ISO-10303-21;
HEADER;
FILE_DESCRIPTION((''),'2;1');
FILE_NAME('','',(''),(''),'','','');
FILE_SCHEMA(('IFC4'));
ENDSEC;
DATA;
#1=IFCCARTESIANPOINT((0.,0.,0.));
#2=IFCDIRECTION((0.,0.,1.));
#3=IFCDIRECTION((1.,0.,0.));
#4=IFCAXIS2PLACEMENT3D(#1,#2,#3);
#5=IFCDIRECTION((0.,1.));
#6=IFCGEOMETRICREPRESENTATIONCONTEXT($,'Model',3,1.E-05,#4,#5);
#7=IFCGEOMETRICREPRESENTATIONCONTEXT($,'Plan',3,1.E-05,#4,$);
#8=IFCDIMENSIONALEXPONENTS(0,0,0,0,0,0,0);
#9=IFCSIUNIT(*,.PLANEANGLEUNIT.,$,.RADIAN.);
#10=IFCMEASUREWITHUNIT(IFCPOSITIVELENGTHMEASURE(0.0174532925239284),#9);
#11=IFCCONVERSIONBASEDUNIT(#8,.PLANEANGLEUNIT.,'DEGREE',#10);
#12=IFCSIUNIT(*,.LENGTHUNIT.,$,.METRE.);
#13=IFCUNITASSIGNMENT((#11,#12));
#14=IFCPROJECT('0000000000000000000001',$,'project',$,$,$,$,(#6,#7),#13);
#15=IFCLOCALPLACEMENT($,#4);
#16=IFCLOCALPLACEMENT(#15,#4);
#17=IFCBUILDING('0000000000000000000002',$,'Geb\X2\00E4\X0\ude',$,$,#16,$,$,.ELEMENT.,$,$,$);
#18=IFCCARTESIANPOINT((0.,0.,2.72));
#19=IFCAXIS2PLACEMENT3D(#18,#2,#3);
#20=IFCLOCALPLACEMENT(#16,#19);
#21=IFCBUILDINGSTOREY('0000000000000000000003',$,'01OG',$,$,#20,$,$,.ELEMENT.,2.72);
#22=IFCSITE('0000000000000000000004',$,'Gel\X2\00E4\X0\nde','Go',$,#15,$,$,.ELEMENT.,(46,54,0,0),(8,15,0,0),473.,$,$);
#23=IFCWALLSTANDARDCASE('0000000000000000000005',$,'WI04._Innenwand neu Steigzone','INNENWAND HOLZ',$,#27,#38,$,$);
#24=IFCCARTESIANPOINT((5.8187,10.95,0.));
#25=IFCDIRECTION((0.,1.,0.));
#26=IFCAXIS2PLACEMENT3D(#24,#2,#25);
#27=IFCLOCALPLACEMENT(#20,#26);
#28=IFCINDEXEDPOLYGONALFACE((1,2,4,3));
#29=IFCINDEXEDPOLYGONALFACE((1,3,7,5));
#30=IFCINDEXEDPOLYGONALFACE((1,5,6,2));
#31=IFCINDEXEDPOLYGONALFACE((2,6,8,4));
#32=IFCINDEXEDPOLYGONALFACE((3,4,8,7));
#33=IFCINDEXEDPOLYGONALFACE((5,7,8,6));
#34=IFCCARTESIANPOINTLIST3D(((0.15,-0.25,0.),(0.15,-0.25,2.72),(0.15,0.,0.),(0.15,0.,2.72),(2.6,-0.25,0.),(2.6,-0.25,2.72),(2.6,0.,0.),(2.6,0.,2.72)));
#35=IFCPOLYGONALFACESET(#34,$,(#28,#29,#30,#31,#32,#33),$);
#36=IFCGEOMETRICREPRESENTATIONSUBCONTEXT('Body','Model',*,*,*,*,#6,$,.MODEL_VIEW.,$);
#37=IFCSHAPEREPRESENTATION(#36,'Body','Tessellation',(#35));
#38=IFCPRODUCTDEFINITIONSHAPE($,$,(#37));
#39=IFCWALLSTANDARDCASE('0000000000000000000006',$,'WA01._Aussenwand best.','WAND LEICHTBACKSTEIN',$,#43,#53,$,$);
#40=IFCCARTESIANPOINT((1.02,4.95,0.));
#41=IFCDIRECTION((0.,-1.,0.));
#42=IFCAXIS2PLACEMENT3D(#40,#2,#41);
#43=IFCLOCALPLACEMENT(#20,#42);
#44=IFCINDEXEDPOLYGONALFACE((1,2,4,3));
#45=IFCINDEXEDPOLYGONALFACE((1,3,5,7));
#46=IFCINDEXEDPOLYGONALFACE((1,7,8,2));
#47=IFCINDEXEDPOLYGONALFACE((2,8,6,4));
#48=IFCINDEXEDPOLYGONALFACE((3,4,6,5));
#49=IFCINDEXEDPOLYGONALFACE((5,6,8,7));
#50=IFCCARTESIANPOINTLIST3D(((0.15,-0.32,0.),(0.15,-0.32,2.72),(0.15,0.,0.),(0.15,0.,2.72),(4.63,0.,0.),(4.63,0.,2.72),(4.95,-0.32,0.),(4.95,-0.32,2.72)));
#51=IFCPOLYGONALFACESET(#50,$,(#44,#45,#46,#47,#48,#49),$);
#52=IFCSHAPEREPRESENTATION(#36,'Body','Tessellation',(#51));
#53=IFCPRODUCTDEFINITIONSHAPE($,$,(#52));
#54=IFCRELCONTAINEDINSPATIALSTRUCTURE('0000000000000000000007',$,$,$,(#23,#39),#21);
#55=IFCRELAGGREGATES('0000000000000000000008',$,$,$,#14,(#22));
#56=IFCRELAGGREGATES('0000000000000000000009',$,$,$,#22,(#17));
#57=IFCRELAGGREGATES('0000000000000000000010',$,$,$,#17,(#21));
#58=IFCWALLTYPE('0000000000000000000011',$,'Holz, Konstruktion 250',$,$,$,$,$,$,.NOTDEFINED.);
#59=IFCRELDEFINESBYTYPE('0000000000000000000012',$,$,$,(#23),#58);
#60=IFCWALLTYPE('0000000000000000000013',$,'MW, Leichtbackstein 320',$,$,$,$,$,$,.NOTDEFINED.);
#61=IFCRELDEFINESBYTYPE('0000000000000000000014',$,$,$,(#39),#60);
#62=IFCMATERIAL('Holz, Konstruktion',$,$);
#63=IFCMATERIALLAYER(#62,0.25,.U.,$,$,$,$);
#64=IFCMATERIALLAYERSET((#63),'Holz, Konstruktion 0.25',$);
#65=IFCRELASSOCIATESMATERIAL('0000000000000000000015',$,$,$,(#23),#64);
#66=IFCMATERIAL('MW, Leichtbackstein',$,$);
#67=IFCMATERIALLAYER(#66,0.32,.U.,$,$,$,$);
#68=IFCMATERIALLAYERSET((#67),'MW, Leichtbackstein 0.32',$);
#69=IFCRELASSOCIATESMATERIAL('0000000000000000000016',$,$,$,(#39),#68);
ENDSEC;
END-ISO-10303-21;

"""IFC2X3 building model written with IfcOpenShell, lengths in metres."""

from ifc_helpers import new_model, entity, si_unit, converted_unit, direction, frame, origin_with_axes, place, context, subcontext, project, spatial, polyline, outline, extrude, material, layer, layer_set, layer_usage, type_object, element, save


model = new_model("IFC2X3")

# Units and contexts
model_context = context("Model", 3, precision=1e-05, world=origin_with_axes(), true_north=direction((0.0, 1.0)))
plan_context = context("Plan", 3, precision=1e-05, world=origin_with_axes())
body_context = subcontext(model_context, "Body", "Model", "MODEL_VIEW")
ifc_project = project(units=[converted_unit("PLANEANGLEUNIT", "DEGREE", entity("IfcPositiveLengthMeasure", 0.0174532925239284), si_unit("PLANEANGLEUNIT", "RADIAN"), dimensions=[0, 0, 0, 0, 0, 0, 0]), si_unit("LENGTHUNIT", "METRE")], contexts=[model_context, plan_context])

# Site, building, storey
site_placement = place(None, origin_with_axes())
site = spatial("IfcSite", under=ifc_project, at=site_placement, Name="Gelände", Description="Go", CompositionType="ELEMENT", RefLatitude=(46, 54, 0, 0), RefLongitude=(8, 15, 0, 0), RefElevation=473.0)
building_placement = place(site_placement, origin_with_axes())
building = spatial("IfcBuilding", under=site, at=building_placement, Name="Gebäude", CompositionType="ELEMENT")
storey_placement = place(building_placement, frame((0.0, 0.0, 2.72), z_axis=(0.0, 0.0, 1.0), x_axis=(1.0, 0.0, 0.0)))
storey = spatial("IfcBuildingStorey", under=building, at=storey_placement, Name="01OG", CompositionType="ELEMENT", Elevation=2.72)

# Shared definitions
ifc_material_1 = material(Name="Holz, Konstruktion")

# Walls
ifc_layer_1 = layer(ifc_material_1, 0.25, ventilated="UNKNOWN")
ifc_layer_set_1 = layer_set([ifc_layer_1], Name="Holz, Konstruktion 0.25")
wall_type_1 = type_object("IfcWallType", Name="Holz, Konstruktion 250", PredefinedType="NOTDEFINED")
ifc_layer_usage_1 = layer_usage(ifc_layer_set_1, "AXIS2", "NEGATIVE", 0.0)
wall_1_placement = place(storey_placement, frame((5.8187, 10.95, 0.0), z_axis=(0.0, 0.0, 1.0), x_axis=(0.0, 1.0, 0.0)))
element("IfcWallStandardCase", 1, at=wall_1_placement, inside=storey, type_object=wall_type_1, material=ifc_layer_usage_1, Name="WI04._Innenwand neu Steigzone", Description="INNENWAND HOLZ", context=body_context, shape_type="SweptSolid", body=[
    extrude(outline(polyline([(0.15, -0.25), (2.6, -0.25), (2.6, 0.0), (0.15, 0.0), (0.15, -0.25)])), origin_with_axes(), (0.0, 0.0, 1.0), 2.72),
])
ifc_material_2 = material(Name="MW, Leichtbackstein")
ifc_layer_2 = layer(ifc_material_2, 0.32, ventilated="UNKNOWN")
ifc_layer_set_2 = layer_set([ifc_layer_2], Name="MW, Leichtbackstein 0.32")
ifc_layer_usage_2 = layer_usage(ifc_layer_set_2, "AXIS2", "POSITIVE", -0.32)
wall_type_2 = type_object("IfcWallType", Name="MW, Leichtbackstein 320", PredefinedType="NOTDEFINED")
wall_2_placement = place(storey_placement, frame((1.02, 4.95, 0.0), z_axis=(0.0, 0.0, 1.0), x_axis=(0.0, -1.0, 0.0)))
element("IfcWallStandardCase", 2, at=wall_2_placement, inside=storey, type_object=wall_type_2, material=ifc_layer_usage_2, Name="WA01._Aussenwand best.", Description="WAND LEICHTBACKSTEIN", context=body_context, shape_type="SweptSolid", body=[
    extrude(outline(polyline([(0.15, -0.32), (4.95, -0.32), (4.63, 0.0), (0.15, 0.0), (0.15, -0.32)])), origin_with_axes(), (0.0, 0.0, 1.0), 2.72),
])

save(model, "model.ifc")
